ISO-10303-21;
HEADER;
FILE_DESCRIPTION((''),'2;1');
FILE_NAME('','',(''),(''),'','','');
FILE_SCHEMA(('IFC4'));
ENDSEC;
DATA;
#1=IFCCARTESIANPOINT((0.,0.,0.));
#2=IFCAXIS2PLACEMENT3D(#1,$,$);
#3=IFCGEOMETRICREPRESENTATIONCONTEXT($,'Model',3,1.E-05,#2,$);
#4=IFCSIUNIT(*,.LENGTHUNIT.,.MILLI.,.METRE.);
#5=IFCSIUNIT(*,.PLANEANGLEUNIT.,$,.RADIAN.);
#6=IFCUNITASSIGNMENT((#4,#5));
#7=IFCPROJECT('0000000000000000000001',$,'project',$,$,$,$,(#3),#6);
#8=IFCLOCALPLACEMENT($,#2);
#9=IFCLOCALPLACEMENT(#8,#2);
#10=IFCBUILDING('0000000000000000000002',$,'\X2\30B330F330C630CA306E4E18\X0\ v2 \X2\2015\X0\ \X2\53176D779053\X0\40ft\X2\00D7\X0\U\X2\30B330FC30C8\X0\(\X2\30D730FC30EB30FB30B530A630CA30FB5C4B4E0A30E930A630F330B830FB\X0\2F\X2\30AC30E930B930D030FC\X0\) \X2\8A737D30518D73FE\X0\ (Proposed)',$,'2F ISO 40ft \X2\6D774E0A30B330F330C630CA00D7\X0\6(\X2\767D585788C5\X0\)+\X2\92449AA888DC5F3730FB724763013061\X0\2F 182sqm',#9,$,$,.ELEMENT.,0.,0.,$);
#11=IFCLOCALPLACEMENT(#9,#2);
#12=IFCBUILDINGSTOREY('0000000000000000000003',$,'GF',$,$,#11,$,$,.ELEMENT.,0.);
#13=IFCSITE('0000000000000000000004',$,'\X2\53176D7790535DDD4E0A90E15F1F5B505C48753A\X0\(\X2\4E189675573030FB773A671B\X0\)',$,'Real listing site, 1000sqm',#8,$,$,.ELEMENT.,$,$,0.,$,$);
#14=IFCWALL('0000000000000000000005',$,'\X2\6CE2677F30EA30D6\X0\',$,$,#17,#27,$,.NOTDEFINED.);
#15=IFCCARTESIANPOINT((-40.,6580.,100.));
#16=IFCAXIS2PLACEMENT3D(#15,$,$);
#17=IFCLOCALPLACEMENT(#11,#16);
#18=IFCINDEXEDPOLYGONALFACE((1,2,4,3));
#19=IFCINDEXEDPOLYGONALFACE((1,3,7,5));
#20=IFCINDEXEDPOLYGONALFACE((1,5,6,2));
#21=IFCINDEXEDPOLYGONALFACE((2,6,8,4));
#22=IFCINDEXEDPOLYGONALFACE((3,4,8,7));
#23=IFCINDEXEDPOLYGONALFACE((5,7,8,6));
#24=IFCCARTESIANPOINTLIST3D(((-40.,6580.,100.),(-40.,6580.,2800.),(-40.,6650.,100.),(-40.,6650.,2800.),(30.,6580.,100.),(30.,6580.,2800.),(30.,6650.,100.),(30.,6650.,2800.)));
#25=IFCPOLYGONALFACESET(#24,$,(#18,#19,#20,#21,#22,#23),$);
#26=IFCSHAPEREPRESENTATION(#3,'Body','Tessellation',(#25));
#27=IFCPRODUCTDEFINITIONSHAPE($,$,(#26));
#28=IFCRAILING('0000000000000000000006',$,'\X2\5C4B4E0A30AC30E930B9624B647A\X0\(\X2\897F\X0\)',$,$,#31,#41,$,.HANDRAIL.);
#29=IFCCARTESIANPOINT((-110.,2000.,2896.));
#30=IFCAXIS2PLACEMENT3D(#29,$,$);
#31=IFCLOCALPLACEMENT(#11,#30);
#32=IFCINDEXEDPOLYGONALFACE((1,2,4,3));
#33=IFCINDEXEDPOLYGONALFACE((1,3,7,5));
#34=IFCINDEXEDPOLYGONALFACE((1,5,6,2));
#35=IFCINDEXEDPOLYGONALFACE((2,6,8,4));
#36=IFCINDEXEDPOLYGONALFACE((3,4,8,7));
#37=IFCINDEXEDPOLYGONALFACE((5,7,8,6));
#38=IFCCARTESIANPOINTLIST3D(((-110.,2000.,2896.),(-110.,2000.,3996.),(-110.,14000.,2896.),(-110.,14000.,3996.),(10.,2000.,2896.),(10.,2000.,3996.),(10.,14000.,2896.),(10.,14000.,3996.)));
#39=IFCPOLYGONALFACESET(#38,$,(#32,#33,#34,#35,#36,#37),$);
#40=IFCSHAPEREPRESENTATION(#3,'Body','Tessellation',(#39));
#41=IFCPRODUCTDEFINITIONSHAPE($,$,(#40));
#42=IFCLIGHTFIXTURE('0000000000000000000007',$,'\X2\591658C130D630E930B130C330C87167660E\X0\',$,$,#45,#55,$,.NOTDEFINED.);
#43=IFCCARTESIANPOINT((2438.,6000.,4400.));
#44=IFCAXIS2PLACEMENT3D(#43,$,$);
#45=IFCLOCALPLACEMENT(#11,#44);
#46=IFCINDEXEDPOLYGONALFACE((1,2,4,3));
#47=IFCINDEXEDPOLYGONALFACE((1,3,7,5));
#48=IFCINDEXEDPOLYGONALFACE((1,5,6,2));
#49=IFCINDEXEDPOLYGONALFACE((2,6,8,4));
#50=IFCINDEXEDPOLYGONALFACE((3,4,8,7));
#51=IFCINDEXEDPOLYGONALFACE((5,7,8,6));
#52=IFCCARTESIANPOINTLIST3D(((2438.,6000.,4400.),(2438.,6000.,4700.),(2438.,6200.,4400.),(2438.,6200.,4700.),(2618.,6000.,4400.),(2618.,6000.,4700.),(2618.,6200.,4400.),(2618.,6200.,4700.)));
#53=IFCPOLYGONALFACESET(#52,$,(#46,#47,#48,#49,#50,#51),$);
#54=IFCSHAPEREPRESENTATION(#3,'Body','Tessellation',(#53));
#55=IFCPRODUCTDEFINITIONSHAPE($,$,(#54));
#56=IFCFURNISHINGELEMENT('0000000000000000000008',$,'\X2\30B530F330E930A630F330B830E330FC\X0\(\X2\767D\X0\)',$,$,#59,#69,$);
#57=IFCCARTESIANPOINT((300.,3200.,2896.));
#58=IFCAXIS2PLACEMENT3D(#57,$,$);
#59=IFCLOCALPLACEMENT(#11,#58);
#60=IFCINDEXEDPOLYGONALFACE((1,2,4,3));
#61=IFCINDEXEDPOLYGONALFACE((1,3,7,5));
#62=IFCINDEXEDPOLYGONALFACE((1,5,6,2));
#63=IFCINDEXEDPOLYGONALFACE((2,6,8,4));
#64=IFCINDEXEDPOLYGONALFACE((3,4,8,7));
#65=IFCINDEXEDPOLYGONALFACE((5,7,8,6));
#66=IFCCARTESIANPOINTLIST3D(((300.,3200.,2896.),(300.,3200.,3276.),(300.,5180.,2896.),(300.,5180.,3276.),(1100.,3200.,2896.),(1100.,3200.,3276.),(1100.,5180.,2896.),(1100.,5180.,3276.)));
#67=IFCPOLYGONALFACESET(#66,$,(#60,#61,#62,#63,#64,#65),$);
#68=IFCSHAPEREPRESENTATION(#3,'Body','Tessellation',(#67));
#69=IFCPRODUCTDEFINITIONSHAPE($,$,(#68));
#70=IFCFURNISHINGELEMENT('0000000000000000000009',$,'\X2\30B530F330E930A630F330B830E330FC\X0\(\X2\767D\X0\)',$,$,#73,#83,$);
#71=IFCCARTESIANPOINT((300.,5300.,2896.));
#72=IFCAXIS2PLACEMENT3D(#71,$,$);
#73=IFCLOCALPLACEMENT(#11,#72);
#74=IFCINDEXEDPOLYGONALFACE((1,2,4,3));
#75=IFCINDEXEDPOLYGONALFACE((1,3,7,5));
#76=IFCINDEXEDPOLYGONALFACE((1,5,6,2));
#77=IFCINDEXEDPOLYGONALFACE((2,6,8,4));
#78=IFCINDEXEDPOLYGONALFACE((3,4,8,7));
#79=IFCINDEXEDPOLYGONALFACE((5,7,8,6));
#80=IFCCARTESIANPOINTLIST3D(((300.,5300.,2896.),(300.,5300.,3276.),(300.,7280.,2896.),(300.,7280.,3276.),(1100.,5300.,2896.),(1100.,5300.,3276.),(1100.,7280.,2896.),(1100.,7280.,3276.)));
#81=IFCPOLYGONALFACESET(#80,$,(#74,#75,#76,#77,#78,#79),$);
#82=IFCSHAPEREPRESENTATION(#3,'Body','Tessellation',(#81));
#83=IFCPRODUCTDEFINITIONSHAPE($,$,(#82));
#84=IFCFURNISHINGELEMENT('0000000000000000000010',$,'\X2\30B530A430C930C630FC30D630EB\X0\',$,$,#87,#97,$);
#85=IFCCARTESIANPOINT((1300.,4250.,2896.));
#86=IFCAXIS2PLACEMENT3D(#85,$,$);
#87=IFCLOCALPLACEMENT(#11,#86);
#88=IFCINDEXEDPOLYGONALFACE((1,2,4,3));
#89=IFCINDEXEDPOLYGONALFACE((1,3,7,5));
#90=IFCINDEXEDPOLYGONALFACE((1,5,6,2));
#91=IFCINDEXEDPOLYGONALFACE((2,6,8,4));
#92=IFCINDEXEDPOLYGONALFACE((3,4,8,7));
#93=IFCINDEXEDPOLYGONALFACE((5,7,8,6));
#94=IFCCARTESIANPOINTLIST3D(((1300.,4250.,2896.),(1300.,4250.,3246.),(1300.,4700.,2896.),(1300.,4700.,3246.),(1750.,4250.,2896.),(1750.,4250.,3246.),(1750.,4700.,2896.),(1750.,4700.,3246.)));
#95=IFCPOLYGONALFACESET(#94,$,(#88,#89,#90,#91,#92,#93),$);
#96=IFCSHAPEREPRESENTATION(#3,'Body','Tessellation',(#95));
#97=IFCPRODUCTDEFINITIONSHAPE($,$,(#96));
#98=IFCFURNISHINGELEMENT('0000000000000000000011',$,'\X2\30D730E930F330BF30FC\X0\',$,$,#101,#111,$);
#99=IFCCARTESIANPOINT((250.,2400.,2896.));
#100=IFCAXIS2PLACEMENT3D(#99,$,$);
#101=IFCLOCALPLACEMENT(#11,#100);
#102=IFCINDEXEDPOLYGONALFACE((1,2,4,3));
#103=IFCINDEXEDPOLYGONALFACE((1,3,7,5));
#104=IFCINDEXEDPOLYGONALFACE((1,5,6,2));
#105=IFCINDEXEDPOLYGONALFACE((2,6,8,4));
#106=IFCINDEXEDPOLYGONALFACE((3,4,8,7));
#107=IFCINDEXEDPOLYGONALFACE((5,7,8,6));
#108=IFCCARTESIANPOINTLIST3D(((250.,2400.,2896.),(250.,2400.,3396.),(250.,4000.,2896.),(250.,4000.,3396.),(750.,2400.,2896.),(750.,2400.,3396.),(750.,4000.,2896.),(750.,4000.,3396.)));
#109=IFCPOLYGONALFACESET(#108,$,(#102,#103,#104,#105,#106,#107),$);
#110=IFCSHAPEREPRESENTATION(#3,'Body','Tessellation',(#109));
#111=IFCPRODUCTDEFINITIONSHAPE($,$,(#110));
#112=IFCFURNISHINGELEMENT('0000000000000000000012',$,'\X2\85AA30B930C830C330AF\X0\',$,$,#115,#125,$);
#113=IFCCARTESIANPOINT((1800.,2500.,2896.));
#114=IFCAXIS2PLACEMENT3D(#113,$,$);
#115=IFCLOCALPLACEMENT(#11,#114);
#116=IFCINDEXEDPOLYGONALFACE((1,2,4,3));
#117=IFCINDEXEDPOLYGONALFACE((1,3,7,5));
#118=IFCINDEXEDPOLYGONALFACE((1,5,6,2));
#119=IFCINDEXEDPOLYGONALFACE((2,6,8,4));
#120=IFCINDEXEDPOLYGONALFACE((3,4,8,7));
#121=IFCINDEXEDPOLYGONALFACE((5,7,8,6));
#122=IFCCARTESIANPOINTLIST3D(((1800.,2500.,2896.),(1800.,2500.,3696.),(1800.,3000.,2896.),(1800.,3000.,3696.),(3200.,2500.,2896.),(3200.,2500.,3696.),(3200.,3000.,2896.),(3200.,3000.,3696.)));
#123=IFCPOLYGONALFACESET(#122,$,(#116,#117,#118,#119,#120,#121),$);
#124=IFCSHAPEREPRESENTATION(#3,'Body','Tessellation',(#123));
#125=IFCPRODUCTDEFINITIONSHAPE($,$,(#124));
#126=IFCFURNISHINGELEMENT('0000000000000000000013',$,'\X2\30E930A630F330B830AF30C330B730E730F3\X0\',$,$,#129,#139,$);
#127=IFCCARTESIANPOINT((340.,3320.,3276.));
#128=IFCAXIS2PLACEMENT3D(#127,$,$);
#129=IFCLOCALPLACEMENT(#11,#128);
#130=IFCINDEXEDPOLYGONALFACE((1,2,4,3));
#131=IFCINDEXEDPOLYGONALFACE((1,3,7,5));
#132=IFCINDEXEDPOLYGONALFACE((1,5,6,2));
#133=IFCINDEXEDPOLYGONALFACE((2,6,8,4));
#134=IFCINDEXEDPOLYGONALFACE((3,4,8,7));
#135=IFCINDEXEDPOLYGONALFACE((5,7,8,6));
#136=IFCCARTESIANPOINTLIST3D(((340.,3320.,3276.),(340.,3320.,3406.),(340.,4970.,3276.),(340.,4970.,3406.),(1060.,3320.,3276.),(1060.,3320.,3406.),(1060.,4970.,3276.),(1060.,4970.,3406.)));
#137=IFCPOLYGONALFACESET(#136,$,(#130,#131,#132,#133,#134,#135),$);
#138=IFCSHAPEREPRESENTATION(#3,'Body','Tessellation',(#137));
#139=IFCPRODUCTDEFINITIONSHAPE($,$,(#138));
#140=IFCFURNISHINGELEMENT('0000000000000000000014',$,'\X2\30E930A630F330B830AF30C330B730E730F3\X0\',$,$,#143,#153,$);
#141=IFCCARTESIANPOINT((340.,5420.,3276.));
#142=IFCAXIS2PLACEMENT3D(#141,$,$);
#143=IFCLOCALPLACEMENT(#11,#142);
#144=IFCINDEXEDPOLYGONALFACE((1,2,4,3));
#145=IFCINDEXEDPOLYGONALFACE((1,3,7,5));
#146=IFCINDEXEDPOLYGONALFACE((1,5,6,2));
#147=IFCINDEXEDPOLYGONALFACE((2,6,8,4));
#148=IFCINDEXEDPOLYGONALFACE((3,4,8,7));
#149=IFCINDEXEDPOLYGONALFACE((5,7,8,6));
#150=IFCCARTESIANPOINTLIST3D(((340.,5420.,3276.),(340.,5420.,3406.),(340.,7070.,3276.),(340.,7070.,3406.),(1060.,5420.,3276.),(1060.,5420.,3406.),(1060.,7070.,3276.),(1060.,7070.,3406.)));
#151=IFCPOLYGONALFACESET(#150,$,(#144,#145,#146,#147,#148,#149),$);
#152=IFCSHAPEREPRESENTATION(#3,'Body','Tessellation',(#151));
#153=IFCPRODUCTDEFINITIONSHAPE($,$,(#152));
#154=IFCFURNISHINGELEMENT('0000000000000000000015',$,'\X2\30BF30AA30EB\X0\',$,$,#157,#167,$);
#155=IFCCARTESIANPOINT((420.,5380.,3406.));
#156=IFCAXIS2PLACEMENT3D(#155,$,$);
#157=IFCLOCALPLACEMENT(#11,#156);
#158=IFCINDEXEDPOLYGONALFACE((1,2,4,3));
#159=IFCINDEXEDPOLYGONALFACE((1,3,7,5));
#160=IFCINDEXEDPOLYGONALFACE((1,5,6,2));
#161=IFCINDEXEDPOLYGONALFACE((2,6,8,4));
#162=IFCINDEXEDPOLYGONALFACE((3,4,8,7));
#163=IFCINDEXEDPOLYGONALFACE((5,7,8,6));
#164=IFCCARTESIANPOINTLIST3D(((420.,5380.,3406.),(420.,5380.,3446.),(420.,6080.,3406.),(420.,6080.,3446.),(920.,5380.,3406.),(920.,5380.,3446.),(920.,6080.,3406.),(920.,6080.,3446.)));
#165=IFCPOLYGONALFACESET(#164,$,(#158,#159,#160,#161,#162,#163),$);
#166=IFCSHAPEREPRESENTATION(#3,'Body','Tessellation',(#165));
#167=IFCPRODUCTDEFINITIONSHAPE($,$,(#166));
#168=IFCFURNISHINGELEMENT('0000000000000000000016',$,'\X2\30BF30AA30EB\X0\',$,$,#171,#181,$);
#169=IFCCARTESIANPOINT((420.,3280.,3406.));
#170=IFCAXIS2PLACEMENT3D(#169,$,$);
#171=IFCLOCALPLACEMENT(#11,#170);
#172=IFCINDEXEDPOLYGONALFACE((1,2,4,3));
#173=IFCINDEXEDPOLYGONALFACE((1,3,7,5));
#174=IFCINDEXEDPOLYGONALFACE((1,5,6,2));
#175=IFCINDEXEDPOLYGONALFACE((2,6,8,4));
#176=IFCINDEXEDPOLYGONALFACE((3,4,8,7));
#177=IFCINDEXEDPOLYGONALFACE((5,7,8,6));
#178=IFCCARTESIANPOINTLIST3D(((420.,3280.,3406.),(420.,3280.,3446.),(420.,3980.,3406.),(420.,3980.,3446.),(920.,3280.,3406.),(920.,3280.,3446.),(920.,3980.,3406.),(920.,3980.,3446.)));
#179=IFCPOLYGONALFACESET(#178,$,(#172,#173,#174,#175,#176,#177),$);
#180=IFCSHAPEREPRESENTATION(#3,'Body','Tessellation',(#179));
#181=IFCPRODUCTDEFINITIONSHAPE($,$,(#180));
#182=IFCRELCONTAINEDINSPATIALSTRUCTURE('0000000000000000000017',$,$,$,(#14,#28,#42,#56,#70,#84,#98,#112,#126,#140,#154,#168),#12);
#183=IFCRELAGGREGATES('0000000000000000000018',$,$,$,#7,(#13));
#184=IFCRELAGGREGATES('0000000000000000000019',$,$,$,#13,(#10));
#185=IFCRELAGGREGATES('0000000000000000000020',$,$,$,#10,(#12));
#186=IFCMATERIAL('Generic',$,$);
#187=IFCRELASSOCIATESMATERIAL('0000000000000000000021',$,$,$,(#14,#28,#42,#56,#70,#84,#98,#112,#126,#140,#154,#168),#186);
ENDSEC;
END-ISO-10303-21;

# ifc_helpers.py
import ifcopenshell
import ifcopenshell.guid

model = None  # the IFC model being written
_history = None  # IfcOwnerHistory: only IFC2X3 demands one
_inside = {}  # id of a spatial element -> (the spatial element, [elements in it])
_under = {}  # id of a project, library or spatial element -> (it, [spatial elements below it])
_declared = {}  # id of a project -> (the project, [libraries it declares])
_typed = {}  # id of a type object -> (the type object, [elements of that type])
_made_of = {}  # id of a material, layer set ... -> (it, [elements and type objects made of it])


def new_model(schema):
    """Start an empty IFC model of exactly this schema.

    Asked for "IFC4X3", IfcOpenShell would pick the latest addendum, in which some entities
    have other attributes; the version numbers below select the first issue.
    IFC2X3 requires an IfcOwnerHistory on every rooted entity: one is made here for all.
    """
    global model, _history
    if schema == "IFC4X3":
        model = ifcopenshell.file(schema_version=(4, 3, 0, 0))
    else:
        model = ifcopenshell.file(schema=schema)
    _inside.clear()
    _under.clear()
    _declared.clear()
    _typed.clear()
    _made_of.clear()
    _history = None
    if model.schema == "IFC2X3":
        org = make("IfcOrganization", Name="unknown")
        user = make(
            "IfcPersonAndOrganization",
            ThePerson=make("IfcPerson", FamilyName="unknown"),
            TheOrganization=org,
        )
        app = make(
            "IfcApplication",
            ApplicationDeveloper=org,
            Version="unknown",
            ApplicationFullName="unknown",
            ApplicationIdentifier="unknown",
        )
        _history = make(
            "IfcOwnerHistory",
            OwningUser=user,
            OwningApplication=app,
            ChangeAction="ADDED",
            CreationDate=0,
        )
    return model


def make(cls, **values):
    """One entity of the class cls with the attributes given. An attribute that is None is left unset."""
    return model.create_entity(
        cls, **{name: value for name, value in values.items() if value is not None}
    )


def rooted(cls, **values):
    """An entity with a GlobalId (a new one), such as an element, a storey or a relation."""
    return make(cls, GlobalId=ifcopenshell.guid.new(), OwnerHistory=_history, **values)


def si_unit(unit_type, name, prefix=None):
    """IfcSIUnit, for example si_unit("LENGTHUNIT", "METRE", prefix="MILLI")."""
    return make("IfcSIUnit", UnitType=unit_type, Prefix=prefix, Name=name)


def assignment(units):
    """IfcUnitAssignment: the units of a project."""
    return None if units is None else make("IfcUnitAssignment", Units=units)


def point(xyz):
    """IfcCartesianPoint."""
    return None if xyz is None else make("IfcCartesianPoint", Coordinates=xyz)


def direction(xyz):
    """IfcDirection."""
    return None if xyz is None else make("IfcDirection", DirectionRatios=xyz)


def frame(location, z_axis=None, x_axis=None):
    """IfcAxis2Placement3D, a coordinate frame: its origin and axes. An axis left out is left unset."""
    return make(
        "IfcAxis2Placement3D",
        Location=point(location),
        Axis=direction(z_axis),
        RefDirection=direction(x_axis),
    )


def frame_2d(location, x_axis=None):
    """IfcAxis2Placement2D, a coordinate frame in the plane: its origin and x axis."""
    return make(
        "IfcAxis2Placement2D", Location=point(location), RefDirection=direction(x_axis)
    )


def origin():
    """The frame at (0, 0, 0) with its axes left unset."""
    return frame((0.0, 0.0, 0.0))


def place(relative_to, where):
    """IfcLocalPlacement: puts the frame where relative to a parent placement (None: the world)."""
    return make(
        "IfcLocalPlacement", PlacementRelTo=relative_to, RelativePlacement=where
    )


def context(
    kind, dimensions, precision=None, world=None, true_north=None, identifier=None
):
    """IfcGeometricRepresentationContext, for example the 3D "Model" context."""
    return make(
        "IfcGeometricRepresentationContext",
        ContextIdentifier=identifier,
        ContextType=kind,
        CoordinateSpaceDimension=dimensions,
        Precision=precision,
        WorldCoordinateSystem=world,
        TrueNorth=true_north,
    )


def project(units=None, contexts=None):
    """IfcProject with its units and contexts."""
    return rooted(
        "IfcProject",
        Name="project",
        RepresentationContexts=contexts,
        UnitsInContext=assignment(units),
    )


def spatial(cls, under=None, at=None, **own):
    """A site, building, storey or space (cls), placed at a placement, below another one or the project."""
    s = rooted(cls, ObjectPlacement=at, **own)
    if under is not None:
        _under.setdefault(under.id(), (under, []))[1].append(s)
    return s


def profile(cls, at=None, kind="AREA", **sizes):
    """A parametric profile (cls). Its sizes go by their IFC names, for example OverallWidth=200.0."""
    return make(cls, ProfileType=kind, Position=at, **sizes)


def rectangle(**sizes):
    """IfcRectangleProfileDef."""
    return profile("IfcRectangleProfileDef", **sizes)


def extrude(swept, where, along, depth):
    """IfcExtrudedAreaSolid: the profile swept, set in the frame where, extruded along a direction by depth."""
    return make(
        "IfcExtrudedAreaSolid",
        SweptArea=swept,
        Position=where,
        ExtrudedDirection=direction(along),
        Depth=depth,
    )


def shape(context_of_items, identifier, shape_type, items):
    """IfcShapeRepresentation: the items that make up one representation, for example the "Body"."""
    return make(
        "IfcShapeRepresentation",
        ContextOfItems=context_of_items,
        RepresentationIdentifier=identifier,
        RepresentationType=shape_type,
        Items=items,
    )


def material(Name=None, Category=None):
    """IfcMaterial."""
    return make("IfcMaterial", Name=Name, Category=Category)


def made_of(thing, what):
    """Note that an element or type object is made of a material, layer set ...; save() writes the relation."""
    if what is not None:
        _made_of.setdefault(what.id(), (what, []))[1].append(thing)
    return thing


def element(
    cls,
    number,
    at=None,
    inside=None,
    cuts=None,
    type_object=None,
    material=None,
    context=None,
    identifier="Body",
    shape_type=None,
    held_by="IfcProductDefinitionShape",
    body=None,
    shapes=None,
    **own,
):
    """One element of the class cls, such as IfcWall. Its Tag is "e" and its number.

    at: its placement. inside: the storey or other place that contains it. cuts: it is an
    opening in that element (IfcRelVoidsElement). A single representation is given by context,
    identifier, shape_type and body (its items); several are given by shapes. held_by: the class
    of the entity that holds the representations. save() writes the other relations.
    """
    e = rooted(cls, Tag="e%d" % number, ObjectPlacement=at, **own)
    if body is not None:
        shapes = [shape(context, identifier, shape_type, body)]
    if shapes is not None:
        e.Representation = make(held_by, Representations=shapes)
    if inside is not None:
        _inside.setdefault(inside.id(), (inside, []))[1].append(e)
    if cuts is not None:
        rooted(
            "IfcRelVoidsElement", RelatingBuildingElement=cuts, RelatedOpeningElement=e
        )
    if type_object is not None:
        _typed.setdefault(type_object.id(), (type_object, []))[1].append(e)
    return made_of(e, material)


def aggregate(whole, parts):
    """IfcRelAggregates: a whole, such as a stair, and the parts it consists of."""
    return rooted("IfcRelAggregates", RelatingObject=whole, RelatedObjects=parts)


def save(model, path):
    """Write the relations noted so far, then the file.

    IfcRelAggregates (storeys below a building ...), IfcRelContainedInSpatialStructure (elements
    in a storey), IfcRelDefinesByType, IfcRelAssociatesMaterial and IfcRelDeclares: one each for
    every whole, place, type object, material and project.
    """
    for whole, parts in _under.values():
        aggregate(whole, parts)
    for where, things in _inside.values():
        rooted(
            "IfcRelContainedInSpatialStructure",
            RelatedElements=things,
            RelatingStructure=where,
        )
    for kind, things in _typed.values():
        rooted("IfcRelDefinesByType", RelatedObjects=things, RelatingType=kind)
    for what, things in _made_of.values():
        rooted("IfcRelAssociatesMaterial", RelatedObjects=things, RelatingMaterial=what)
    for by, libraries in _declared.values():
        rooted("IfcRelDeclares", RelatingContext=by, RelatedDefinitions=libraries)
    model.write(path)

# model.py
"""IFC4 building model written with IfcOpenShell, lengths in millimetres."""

from ifc_helpers import new_model, si_unit, frame, frame_2d, origin, place, context, project, spatial, rectangle, extrude, material, element, save


model = new_model("IFC4")

# Units and contexts
model_context = context("Model", 3, precision=1e-05, world=origin())
ifc_project = project(units=[si_unit("LENGTHUNIT", "METRE", prefix="MILLI"), si_unit("PLANEANGLEUNIT", "RADIAN")], contexts=[model_context])

# Site, building, storey
site_placement = place(None, origin())
site = spatial("IfcSite", under=ifc_project, at=site_placement, Name="北海道川上郡弟子屈町(丘陵地・眺望)", ObjectType="Real listing site, 1000sqm", CompositionType="ELEMENT", RefElevation=0.0)
building_placement = place(site_placement, origin())
building = spatial("IfcBuilding", under=site, at=building_placement, Name="コンテナの丘 v2 ― 北海道40ft×Uコート(プール・サウナ・屋上ラウンジ・2Fガラスバー) 詳細再現 (Proposed)", ObjectType="2F ISO 40ft 海上コンテナ×6(白塗装)+鉄骨補強・片持ち2F 182sqm", CompositionType="ELEMENT", ElevationOfRefHeight=0.0, ElevationOfTerrain=0.0)
storey_placement = place(building_placement, origin())
storey = spatial("IfcBuildingStorey", under=building, at=storey_placement, Name="GF", CompositionType="ELEMENT", Elevation=0.0)

# Shared definitions
ifc_material = material(Name="Generic")

# Wall
wall_1_placement = place(storey_placement, frame((-40.0, 6580.0, 100.0)))
element("IfcWall", 1, at=wall_1_placement, inside=storey, material=ifc_material, Name="波板リブ", PredefinedType="NOTDEFINED", context=model_context, shape_type="SweptSolid", body=[
    extrude(rectangle(XDim=70.0, YDim=70.0, at=frame_2d((35.0, 35.0))), frame((-40.0, 6580.0, 100.0)), (0.0, 0.0, 1.0), 2700.0),
])

# Railing
railing_placement = place(storey_placement, frame((-110.0, 2000.0, 2896.0)))
element("IfcRailing", 2, at=railing_placement, inside=storey, material=ifc_material, Name="屋上ガラス手摺(西)", PredefinedType="HANDRAIL", context=model_context, shape_type="SweptSolid", body=[
    extrude(rectangle(XDim=120.0, YDim=12000.0, at=frame_2d((60.0, 6000.0))), frame((-110.0, 2000.0, 2896.0)), (0.0, 0.0, 1.0), 1100.0),
])

# Light fixture
light_fixture_placement = place(storey_placement, frame((2438.0, 6000.0, 4400.0)))
element("IfcLightFixture", 3, at=light_fixture_placement, inside=storey, material=ifc_material, Name="外壁ブラケット照明", PredefinedType="NOTDEFINED", context=model_context, shape_type="SweptSolid", body=[
    extrude(rectangle(XDim=180.0, YDim=200.0, at=frame_2d((90.0, 100.0))), frame((2438.0, 6000.0, 4400.0)), (0.0, 0.0, 1.0), 300.0),
])

# Furnishing elements
furnishing_1_placement = place(storey_placement, frame((300.0, 3200.0, 2896.0)))
element("IfcFurnishingElement", 4, at=furnishing_1_placement, inside=storey, material=ifc_material, Name="サンラウンジャー(白)", context=model_context, shape_type="SweptSolid", body=[
    extrude(rectangle(XDim=800.0, YDim=1980.0, at=frame_2d((400.0, 990.0))), frame((300.0, 3200.0, 2896.0)), (0.0, 0.0, 1.0), 380.0),
])
furnishing_2_placement = place(storey_placement, frame((300.0, 5300.0, 2896.0)))
element("IfcFurnishingElement", 5, at=furnishing_2_placement, inside=storey, material=ifc_material, Name="サンラウンジャー(白)", context=model_context, shape_type="SweptSolid", body=[
    extrude(rectangle(XDim=800.0, YDim=1980.0, at=frame_2d((400.0, 990.0))), frame((300.0, 5300.0, 2896.0)), (0.0, 0.0, 1.0), 380.0),
])
furnishing_3_placement = place(storey_placement, frame((1300.0, 4250.0, 2896.0)))
element("IfcFurnishingElement", 6, at=furnishing_3_placement, inside=storey, material=ifc_material, Name="サイドテーブル", context=model_context, shape_type="SweptSolid", body=[
    extrude(rectangle(XDim=450.0, YDim=450.0, at=frame_2d((225.0, 225.0))), frame((1300.0, 4250.0, 2896.0)), (0.0, 0.0, 1.0), 350.0),
])
furnishing_4_placement = place(storey_placement, frame((250.0, 2400.0, 2896.0)))
element("IfcFurnishingElement", 7, at=furnishing_4_placement, inside=storey, material=ifc_material, Name="プランター", context=model_context, shape_type="SweptSolid", body=[
    extrude(rectangle(XDim=500.0, YDim=1600.0, at=frame_2d((250.0, 800.0))), frame((250.0, 2400.0, 2896.0)), (0.0, 0.0, 1.0), 500.0),
])
furnishing_5_placement = place(storey_placement, frame((1800.0, 2500.0, 2896.0)))
element("IfcFurnishingElement", 8, at=furnishing_5_placement, inside=storey, material=ifc_material, Name="薪ストック", context=model_context, shape_type="SweptSolid", body=[
    extrude(rectangle(XDim=1400.0, YDim=500.0, at=frame_2d((700.0, 250.0))), frame((1800.0, 2500.0, 2896.0)), (0.0, 0.0, 1.0), 800.0),
])
furnishing_6_placement = place(storey_placement, frame((340.0, 3320.0, 3276.0)))
element("IfcFurnishingElement", 9, at=furnishing_6_placement, inside=storey, material=ifc_material, Name="ラウンジクッション", context=model_context, shape_type="SweptSolid", body=[
    extrude(rectangle(XDim=720.0, YDim=1650.0, at=frame_2d((360.0, 825.0))), frame((340.0, 3320.0, 3276.0)), (0.0, 0.0, 1.0), 130.0),
])
furnishing_7_placement = place(storey_placement, frame((340.0, 5420.0, 3276.0)))
element("IfcFurnishingElement", 10, at=furnishing_7_placement, inside=storey, material=ifc_material, Name="ラウンジクッション", context=model_context, shape_type="SweptSolid", body=[
    extrude(rectangle(XDim=720.0, YDim=1650.0, at=frame_2d((360.0, 825.0))), frame((340.0, 5420.0, 3276.0)), (0.0, 0.0, 1.0), 130.0),
])
furnishing_8_placement = place(storey_placement, frame((420.0, 5380.0, 3406.0)))
element("IfcFurnishingElement", 11, at=furnishing_8_placement, inside=storey, material=ifc_material, Name="タオル", context=model_context, shape_type="SweptSolid", body=[
    extrude(rectangle(XDim=500.0, YDim=700.0, at=frame_2d((250.0, 350.0))), frame((420.0, 5380.0, 3406.0)), (0.0, 0.0, 1.0), 40.0),
])
furnishing_9_placement = place(storey_placement, frame((420.0, 3280.0, 3406.0)))
element("IfcFurnishingElement", 12, at=furnishing_9_placement, inside=storey, material=ifc_material, Name="タオル", context=model_context, shape_type="SweptSolid", body=[
    extrude(rectangle(XDim=500.0, YDim=700.0, at=frame_2d((250.0, 350.0))), frame((420.0, 3280.0, 3406.0)), (0.0, 0.0, 1.0), 40.0),
])

save(model, "model.ifc")
